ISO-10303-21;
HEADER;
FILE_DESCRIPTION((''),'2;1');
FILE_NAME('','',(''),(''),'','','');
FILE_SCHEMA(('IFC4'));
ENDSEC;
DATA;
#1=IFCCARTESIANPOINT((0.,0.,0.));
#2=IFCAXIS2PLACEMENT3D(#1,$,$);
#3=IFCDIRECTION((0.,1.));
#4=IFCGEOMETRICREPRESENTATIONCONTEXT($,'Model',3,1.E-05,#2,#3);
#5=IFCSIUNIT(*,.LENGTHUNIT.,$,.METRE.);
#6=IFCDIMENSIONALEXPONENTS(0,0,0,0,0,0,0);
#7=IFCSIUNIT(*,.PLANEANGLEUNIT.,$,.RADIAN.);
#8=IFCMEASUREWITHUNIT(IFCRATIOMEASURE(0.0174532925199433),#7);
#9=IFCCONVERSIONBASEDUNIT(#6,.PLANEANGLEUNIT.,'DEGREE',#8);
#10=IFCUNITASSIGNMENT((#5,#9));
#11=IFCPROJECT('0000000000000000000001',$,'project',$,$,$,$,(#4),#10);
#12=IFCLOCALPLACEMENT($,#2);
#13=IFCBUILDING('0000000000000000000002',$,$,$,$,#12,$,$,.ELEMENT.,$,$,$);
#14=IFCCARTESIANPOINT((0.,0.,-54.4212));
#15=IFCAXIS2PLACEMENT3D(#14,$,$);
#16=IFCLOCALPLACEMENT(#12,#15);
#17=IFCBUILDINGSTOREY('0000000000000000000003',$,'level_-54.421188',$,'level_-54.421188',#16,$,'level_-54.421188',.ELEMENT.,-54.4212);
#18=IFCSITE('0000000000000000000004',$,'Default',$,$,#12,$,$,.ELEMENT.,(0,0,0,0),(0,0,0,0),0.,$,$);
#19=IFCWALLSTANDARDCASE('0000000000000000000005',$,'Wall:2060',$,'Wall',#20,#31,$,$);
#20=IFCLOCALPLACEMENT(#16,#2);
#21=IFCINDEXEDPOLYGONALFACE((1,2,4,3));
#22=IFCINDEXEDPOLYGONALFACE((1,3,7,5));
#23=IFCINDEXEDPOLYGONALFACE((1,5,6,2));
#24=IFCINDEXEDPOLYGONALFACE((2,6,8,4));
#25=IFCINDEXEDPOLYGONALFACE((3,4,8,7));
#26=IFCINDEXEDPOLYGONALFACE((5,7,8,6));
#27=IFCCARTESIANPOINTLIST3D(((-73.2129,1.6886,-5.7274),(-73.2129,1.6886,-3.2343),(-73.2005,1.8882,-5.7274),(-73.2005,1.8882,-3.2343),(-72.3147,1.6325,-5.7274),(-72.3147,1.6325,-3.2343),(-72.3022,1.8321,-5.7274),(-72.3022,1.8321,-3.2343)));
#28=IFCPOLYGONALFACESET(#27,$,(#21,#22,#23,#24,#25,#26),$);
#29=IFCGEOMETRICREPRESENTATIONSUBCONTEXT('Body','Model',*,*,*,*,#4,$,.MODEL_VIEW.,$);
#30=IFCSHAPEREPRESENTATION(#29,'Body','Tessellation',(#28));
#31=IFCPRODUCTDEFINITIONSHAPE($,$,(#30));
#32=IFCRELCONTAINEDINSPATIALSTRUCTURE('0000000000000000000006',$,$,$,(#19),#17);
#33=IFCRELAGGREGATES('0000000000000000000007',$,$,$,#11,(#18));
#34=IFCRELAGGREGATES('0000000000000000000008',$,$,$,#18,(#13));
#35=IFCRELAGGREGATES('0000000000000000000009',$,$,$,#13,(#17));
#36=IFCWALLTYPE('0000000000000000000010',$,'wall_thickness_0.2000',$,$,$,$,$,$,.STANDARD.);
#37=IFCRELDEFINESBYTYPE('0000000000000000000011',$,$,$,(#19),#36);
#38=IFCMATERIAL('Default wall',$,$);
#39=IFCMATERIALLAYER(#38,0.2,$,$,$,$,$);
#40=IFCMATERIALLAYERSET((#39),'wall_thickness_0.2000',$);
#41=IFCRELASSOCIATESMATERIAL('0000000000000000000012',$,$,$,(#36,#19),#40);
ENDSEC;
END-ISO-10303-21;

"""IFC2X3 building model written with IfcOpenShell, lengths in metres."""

from ifc_helpers import new_model, entity, si_unit, converted_unit, direction, frame, origin, place, context, subcontext, project, spatial, polyline, outline, extrude, material, layer, layer_set, layer_usage, type_object, element, save


model = new_model("IFC2X3")

# Units and contexts
model_context = context("Model", 3, precision=1e-05, world=origin(), true_north=direction((0.0, 1.0)))
body_context = subcontext(model_context, "Body", "Model", "MODEL_VIEW")
ifc_project = project(units=[si_unit("LENGTHUNIT", "METRE"), converted_unit("PLANEANGLEUNIT", "DEGREE", entity("IfcRatioMeasure", 0.0174532925199433), si_unit("PLANEANGLEUNIT", "RADIAN"), dimensions=[0, 0, 0, 0, 0, 0, 0])], contexts=[model_context])

# Site, building, storey
placement_1 = place(None, origin())
site = spatial("IfcSite", under=ifc_project, at=placement_1, Name="Default", CompositionType="ELEMENT", RefLatitude=(0, 0, 0, 0), RefLongitude=(0, 0, 0, 0), RefElevation=0.0)
building = spatial("IfcBuilding", under=site, at=placement_1, CompositionType="ELEMENT")
storey_placement = place(placement_1, frame((0.0, 0.0, -54.4212)))
storey = spatial("IfcBuildingStorey", under=building, at=storey_placement, Name="level_-54.421188", ObjectType="level_-54.421188", LongName="level_-54.421188", CompositionType="ELEMENT", Elevation=-54.4212)

# Shared definitions
ifc_material_1 = material(Name="Default wall")
ifc_layer = layer(ifc_material_1, 0.2)
ifc_layer_set = layer_set([ifc_layer], Name="wall_thickness_0.2000")
ifc_layer_usage = layer_usage(ifc_layer_set, "AXIS2", "POSITIVE", -0.1)
wall_type = type_object("IfcWallType", Name="wall_thickness_0.2000", PredefinedType="STANDARD", material=ifc_layer_set)

# Wall
placement_2 = place(placement_1, frame((0.0, 0.0, -60.1486)))
wall_1_placement = place(placement_2, frame((-73.2067, 1.7884, 0.0), z_axis=(0.0, 0.0, 1.0), x_axis=(0.998056, -0.062317, 0.0)))
element("IfcWallStandardCase", 1, at=wall_1_placement, inside=storey, type_object=wall_type, material=ifc_layer_usage, Name="Wall:2060", ObjectType="Wall", context=body_context, shape_type="SweptSolid", body=[
    extrude(outline(polyline([(0.9, -0.1), (0.9, 0.1), (0.0, 0.1), (0.0, -0.1), (0.9, -0.1)])), origin(), (0.0, 0.0, 1.0), 2.4931),
])

save(model, "model.ifc")
